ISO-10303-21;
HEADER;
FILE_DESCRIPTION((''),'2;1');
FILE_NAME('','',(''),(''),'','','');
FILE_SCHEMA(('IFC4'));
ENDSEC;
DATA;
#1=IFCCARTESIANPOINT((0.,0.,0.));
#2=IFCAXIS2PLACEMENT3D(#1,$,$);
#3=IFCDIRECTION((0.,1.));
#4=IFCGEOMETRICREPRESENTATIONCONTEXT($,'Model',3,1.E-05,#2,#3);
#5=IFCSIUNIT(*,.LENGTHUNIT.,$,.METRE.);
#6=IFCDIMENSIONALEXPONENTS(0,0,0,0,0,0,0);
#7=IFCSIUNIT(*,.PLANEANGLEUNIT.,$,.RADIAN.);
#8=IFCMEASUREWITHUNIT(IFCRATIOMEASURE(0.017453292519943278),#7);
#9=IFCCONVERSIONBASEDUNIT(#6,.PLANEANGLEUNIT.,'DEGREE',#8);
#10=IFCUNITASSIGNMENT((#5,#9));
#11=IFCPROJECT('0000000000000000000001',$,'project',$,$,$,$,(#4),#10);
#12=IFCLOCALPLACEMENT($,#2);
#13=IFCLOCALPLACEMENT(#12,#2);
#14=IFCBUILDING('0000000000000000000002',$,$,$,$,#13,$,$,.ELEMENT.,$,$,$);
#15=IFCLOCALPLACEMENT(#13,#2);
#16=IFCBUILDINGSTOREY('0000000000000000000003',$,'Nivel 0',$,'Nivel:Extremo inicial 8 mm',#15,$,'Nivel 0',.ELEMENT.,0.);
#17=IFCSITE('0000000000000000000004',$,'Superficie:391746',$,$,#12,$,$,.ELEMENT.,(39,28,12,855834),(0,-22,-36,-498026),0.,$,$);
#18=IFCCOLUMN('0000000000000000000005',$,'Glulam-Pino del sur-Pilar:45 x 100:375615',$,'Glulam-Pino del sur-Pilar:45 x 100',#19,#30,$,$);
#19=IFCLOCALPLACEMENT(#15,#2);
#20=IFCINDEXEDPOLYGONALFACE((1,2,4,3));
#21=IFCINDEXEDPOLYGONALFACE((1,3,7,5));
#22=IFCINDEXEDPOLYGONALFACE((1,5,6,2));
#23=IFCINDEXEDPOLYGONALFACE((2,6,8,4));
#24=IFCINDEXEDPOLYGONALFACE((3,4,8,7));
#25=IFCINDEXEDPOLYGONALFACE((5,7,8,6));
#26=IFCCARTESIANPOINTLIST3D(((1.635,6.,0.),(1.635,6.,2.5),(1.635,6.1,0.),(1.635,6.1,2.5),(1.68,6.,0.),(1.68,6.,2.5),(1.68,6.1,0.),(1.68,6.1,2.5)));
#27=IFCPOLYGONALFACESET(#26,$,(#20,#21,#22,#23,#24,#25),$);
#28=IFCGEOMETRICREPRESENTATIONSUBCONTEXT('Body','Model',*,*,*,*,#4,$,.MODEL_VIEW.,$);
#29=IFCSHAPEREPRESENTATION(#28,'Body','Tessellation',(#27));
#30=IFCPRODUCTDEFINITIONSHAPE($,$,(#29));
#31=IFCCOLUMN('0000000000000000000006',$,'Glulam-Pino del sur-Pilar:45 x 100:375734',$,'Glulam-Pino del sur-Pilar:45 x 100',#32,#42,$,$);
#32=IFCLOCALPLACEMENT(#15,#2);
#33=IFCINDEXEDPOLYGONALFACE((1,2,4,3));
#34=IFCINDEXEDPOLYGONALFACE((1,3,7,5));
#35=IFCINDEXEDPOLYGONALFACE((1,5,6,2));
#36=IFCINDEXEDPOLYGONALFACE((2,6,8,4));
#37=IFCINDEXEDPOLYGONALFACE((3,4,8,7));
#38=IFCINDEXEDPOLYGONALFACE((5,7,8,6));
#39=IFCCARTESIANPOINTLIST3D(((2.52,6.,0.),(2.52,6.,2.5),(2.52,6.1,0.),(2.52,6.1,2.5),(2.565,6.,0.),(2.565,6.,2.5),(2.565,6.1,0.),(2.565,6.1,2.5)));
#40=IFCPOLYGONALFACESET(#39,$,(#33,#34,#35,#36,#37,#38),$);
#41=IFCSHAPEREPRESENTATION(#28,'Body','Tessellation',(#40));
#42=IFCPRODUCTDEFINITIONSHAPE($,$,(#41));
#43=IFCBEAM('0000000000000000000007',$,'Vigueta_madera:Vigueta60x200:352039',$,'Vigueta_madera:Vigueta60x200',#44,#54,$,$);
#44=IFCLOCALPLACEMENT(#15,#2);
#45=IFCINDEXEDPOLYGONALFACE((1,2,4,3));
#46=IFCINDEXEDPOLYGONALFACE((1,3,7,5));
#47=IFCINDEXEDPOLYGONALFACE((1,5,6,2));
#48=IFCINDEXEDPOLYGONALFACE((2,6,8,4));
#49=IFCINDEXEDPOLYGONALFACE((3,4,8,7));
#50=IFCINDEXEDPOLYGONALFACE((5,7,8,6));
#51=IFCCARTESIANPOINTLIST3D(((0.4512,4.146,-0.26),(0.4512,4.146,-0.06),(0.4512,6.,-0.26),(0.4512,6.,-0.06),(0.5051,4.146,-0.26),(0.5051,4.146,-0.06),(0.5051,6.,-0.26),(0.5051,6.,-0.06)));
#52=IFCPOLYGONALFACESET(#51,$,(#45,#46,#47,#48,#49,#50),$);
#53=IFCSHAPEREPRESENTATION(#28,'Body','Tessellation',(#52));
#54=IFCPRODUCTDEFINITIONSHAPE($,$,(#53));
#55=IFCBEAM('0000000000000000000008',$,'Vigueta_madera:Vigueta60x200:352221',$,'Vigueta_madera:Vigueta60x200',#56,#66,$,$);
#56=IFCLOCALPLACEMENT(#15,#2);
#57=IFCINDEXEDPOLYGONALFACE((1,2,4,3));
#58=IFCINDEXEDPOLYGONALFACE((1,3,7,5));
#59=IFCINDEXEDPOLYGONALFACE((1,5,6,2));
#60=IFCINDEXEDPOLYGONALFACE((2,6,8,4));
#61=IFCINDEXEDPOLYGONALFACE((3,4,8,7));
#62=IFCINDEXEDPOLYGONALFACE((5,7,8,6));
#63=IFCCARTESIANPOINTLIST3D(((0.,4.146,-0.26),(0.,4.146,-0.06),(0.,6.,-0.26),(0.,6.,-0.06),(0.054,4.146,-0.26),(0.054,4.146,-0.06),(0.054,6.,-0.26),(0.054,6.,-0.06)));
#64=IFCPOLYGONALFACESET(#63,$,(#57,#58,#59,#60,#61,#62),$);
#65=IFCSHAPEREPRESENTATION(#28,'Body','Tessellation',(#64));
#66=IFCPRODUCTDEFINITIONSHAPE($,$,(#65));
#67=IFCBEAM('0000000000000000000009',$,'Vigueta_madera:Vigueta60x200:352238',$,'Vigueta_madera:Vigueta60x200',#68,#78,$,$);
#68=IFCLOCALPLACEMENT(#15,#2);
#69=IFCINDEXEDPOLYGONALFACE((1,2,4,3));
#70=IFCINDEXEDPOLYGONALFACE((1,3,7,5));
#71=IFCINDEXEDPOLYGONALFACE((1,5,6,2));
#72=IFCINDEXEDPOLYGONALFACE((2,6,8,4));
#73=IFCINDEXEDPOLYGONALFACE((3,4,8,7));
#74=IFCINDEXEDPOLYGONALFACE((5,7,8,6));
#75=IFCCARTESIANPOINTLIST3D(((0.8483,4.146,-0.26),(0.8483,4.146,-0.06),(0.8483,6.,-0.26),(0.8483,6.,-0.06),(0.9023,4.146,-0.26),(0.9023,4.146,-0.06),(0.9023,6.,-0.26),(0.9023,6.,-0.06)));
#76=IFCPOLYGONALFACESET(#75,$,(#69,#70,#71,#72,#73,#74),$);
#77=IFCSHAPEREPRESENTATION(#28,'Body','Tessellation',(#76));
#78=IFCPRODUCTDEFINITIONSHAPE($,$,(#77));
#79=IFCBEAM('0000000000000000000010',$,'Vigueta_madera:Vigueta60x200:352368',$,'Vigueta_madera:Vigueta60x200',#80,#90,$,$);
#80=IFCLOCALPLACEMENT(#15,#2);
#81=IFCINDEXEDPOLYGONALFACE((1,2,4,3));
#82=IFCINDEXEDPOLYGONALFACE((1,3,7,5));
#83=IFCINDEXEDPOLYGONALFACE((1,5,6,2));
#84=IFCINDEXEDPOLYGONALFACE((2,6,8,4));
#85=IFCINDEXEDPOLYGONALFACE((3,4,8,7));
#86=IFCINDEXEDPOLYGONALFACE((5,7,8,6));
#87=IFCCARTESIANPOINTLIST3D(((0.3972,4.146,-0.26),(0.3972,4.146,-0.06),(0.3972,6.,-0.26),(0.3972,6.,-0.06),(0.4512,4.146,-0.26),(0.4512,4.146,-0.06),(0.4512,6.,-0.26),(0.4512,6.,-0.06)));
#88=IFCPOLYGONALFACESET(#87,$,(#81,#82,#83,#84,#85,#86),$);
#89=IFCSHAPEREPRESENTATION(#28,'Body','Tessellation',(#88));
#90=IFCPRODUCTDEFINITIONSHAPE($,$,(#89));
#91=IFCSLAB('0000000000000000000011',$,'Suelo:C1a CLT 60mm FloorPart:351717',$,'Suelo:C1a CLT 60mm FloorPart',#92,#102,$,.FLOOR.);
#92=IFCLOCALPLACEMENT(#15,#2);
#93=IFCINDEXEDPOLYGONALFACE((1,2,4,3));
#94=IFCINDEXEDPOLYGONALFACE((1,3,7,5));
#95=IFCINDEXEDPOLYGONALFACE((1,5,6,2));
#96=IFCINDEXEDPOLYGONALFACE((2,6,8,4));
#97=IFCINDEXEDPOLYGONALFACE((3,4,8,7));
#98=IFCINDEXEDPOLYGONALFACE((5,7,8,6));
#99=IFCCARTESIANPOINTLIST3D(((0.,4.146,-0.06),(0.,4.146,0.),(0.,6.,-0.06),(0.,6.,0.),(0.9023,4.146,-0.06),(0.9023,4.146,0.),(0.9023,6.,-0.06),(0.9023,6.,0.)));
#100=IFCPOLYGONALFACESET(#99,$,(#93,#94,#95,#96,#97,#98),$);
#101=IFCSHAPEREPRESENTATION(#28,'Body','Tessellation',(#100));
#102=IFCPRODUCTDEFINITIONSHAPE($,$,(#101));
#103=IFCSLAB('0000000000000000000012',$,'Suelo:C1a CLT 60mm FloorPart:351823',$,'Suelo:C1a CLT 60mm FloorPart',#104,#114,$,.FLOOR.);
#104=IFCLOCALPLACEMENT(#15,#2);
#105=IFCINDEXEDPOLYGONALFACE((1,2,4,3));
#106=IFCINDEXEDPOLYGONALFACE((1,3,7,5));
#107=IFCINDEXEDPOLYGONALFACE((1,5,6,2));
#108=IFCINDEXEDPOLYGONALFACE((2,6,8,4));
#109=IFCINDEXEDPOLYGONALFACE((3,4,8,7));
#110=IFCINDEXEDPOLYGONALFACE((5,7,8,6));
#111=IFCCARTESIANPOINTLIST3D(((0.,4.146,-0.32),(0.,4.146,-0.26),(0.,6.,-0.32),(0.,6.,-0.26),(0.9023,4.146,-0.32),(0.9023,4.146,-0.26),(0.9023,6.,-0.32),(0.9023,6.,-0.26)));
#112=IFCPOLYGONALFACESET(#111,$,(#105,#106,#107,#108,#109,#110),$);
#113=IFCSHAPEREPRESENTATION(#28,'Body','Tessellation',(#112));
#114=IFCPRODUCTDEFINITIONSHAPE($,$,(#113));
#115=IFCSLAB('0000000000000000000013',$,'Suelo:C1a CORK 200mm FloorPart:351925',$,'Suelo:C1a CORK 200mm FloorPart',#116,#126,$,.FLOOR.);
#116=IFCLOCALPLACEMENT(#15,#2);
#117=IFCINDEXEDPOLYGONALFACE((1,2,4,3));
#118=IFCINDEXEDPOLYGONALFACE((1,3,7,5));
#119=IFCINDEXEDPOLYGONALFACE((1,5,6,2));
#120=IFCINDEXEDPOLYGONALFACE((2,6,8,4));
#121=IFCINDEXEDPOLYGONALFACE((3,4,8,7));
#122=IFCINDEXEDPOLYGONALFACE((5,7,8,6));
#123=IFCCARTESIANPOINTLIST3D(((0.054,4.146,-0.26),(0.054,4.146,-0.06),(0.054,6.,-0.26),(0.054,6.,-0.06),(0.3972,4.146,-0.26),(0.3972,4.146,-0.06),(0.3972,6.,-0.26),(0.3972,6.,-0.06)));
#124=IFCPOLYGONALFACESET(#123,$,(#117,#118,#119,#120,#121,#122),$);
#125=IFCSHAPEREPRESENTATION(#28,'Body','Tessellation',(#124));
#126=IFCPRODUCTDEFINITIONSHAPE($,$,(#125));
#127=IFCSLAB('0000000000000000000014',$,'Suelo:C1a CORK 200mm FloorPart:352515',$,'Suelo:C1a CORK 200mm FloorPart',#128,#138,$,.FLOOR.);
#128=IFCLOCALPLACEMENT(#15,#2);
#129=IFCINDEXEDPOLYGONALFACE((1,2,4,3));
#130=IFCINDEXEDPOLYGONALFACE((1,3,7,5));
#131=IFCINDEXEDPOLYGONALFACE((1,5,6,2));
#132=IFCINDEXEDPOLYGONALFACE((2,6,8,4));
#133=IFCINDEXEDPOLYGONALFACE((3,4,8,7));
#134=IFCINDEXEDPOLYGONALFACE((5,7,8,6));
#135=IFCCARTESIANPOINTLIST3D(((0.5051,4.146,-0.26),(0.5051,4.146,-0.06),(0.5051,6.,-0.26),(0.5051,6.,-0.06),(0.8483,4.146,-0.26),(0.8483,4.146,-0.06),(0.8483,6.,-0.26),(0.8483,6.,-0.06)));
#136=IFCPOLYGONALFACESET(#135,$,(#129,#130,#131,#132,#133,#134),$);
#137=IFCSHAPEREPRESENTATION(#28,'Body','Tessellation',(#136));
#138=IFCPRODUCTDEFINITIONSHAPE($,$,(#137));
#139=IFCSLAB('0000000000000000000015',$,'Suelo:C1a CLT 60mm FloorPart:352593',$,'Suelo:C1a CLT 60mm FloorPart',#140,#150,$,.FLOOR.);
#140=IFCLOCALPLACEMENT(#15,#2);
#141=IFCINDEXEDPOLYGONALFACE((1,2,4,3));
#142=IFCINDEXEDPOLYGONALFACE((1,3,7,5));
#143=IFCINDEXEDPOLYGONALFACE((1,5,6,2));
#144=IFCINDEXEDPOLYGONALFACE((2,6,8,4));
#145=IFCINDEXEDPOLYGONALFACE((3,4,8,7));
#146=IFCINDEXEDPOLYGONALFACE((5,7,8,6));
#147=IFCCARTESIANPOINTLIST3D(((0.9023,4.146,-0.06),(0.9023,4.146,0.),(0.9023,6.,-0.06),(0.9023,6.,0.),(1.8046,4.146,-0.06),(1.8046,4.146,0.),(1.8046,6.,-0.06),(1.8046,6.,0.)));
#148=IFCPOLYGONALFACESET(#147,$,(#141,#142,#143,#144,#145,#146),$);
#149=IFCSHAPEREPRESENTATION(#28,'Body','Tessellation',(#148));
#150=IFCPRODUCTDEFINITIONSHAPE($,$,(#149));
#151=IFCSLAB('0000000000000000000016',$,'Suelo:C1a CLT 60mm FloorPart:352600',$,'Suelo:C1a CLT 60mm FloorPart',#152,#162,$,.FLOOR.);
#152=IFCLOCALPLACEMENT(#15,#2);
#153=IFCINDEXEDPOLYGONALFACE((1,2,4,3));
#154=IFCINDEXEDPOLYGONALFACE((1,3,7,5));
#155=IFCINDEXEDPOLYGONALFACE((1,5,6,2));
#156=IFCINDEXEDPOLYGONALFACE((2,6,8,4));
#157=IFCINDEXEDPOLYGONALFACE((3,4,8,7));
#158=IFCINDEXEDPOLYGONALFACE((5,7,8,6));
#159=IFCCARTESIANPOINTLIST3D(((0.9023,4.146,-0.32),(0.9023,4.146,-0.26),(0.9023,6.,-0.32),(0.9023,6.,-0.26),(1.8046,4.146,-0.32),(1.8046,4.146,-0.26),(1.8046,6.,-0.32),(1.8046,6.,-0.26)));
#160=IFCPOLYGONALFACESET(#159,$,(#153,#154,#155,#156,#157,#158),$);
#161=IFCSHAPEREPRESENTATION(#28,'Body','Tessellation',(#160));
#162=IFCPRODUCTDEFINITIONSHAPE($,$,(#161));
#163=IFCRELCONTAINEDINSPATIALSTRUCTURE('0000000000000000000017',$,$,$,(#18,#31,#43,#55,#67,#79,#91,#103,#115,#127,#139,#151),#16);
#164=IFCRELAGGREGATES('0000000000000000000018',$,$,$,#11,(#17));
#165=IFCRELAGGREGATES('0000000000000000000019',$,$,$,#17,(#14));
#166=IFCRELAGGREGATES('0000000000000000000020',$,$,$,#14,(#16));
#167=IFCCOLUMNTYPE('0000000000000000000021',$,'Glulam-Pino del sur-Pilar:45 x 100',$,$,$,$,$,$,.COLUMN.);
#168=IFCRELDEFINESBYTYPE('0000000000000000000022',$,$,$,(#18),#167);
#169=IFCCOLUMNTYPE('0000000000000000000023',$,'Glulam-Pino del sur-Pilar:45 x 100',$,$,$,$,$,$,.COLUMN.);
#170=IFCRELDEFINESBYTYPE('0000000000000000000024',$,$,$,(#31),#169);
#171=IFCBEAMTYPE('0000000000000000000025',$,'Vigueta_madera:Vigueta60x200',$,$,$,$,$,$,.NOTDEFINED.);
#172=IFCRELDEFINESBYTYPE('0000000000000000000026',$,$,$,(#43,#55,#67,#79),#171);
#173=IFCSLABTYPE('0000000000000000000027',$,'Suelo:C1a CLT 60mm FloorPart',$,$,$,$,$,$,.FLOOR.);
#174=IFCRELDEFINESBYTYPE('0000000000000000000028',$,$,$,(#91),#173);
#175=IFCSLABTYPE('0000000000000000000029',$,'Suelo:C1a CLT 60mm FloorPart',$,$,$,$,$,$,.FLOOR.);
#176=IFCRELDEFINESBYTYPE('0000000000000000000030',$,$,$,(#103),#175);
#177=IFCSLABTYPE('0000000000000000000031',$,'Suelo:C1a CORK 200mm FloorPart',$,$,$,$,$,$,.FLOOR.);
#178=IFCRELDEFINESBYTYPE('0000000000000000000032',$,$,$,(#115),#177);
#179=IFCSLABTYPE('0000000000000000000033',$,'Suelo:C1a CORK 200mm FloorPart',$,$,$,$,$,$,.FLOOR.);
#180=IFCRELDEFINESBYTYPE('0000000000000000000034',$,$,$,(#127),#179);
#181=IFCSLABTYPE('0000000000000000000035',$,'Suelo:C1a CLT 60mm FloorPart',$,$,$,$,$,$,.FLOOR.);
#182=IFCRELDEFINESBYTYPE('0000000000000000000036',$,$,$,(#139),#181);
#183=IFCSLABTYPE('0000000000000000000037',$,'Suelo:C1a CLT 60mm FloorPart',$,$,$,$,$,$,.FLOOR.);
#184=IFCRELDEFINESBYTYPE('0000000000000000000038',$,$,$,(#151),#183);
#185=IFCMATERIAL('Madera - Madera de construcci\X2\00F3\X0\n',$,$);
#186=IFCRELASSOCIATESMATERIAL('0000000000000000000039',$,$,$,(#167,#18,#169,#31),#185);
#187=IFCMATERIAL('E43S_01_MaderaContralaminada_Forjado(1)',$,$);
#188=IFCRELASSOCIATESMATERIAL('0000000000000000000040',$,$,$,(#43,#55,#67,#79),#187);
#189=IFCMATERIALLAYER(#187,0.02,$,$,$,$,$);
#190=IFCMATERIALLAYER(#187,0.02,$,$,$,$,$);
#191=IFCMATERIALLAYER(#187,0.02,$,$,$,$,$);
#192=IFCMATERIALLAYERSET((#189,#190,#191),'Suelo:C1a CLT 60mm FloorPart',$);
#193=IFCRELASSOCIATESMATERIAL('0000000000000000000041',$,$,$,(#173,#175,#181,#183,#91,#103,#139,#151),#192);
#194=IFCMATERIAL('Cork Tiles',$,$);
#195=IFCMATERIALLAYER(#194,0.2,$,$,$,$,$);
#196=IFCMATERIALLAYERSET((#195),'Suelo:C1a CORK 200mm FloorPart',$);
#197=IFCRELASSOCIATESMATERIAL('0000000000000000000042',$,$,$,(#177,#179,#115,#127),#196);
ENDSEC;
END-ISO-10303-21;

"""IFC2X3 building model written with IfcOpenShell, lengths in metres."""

from ifc_helpers import new_model, entity, si_unit, converted_unit, direction, frame, frame_2d, origin, origin_2d_with_axis, place, context, subcontext, project, spatial, rectangle, extrude, source, transform, mapped, material, layer, layer_set, layer_usage, type_object, type_shapes, element, save


model = new_model("IFC2X3")

# Units and contexts
model_context = context("Model", 3, precision=1e-05, world=origin(), true_north=direction((0.0, 1.0)))
body_context = subcontext(model_context, "Body", "Model", "MODEL_VIEW")
ifc_project = project(units=[si_unit("LENGTHUNIT", "METRE"), converted_unit("PLANEANGLEUNIT", "DEGREE", entity("IfcRatioMeasure", 0.017453292519943278), si_unit("PLANEANGLEUNIT", "RADIAN"), dimensions=[0, 0, 0, 0, 0, 0, 0])], contexts=[model_context])

# Site, building, storey
site_placement = place(None, origin())
site = spatial("IfcSite", under=ifc_project, at=site_placement, Name="Superficie:391746", CompositionType="ELEMENT", RefLatitude=(39, 28, 12, 855834), RefLongitude=(0, -22, -36, -498026), RefElevation=0.0)
building_placement = place(site_placement, origin())
building = spatial("IfcBuilding", under=site, at=building_placement, CompositionType="ELEMENT")
storey_placement = place(building_placement, origin())
storey = spatial("IfcBuildingStorey", under=building, at=storey_placement, Name="Nivel 0", ObjectType="Nivel:Extremo inicial 8 mm", LongName="Nivel 0", CompositionType="ELEMENT", Elevation=0.0)

# Columns
ifc_material_1 = material(Name="Madera - Madera de construcción")
column_type_1 = type_object("IfcColumnType", Name="Glulam-Pino del sur-Pilar:45 x 100", PredefinedType="COLUMN", material=ifc_material_1)
shared_shape_1 = source(origin(), body_context, "Body", "SweptSolid", [
    extrude(rectangle(XDim=0.1, YDim=0.045, at=origin_2d_with_axis()), frame((0.0, 0.0, 0.0), z_axis=(0.0, 0.0, 1.0), x_axis=(0.0, -1.0, 0.0)), (0.0, 0.0, 1.0), 2.5),
])
type_shapes(column_type_1, [shared_shape_1])
column_1_placement = place(storey_placement, frame((1.6575, 6.05, 0.0)))
element("IfcColumn", 1, at=column_1_placement, inside=storey, type_object=column_type_1, material=ifc_material_1, Name="Glulam-Pino del sur-Pilar:45 x 100:375615", ObjectType="Glulam-Pino del sur-Pilar:45 x 100", context=body_context, shape_type="MappedRepresentation", body=[
    mapped(shared_shape_1, transform((0.0, 0.0, 0.0), scale=1.0)),
])
column_type_2 = type_object("IfcColumnType", Name="Glulam-Pino del sur-Pilar:45 x 100", PredefinedType="COLUMN", material=ifc_material_1)
shared_shape_2 = source(origin(), body_context, "Body", "SweptSolid", [
    extrude(rectangle(XDim=0.1, YDim=0.045, at=origin_2d_with_axis()), frame((0.0, 0.0, 0.0), z_axis=(0.0, 0.0, 1.0), x_axis=(0.0, -1.0, 0.0)), (0.0, 0.0, 1.0), 2.5),
])
type_shapes(column_type_2, [shared_shape_2])
column_2_placement = place(storey_placement, frame((2.5425, 6.05, 0.0), z_axis=(0.0, 0.0, 1.0), x_axis=(-1.0, 0.0, 0.0)))
element("IfcColumn", 2, at=column_2_placement, inside=storey, type_object=column_type_2, material=ifc_material_1, Name="Glulam-Pino del sur-Pilar:45 x 100:375734", ObjectType="Glulam-Pino del sur-Pilar:45 x 100", context=body_context, shape_type="MappedRepresentation", body=[
    mapped(shared_shape_2, transform((0.0, 0.0, 0.0), scale=1.0)),
])

# Beams
ifc_material_2 = material(Name="E43S_01_MaderaContralaminada_Forjado(1)")
beam_type = type_object("IfcBeamType", Name="Vigueta_madera:Vigueta60x200", PredefinedType="NOTDEFINED")
beam_1_placement = place(storey_placement, frame((0.4781, 4.146, -0.06), z_axis=(0.0, 0.0, 1.0), x_axis=(0.0, 1.0, 0.0)))
element("IfcBeam", 3, at=beam_1_placement, inside=storey, type_object=beam_type, material=ifc_material_2, Name="Vigueta_madera:Vigueta60x200:352039", ObjectType="Vigueta_madera:Vigueta60x200", context=body_context, shape_type="SweptSolid", body=[
    extrude(rectangle(XDim=0.2, YDim=0.054, at=frame_2d((0.0, 0.0), x_axis=(1.0, 0.0))), frame((0.0, 0.0, -0.1), z_axis=(1.0, 0.0, 0.0), x_axis=(0.0, 0.0, -1.0)), (0.0, 0.0, 1.0), 1.854),
])
beam_2_placement = place(storey_placement, frame((0.027, 4.146, -0.06), z_axis=(0.0, 0.0, 1.0), x_axis=(0.0, 1.0, 0.0)))
element("IfcBeam", 4, at=beam_2_placement, inside=storey, type_object=beam_type, material=ifc_material_2, Name="Vigueta_madera:Vigueta60x200:352221", ObjectType="Vigueta_madera:Vigueta60x200", context=body_context, shape_type="SweptSolid", body=[
    extrude(rectangle(XDim=0.2, YDim=0.054, at=frame_2d((0.0, 0.0), x_axis=(1.0, 0.0))), frame((0.0, 0.0, -0.1), z_axis=(1.0, 0.0, 0.0), x_axis=(0.0, 0.0, -1.0)), (0.0, 0.0, 1.0), 1.854),
])
beam_3_placement = place(storey_placement, frame((0.8753, 4.146, -0.06), z_axis=(0.0, 0.0, 1.0), x_axis=(0.0, 1.0, 0.0)))
element("IfcBeam", 5, at=beam_3_placement, inside=storey, type_object=beam_type, material=ifc_material_2, Name="Vigueta_madera:Vigueta60x200:352238", ObjectType="Vigueta_madera:Vigueta60x200", context=body_context, shape_type="SweptSolid", body=[
    extrude(rectangle(XDim=0.2, YDim=0.054, at=frame_2d((0.0, 0.0), x_axis=(1.0, 0.0))), frame((0.0, 0.0, -0.1), z_axis=(1.0, 0.0, 0.0), x_axis=(0.0, 0.0, -1.0)), (0.0, 0.0, 1.0), 1.854),
])
beam_4_placement = place(storey_placement, frame((0.4242, 4.146, -0.06), z_axis=(0.0, 0.0, 1.0), x_axis=(0.0, 1.0, 0.0)))
element("IfcBeam", 6, at=beam_4_placement, inside=storey, type_object=beam_type, material=ifc_material_2, Name="Vigueta_madera:Vigueta60x200:352368", ObjectType="Vigueta_madera:Vigueta60x200", context=body_context, shape_type="SweptSolid", body=[
    extrude(rectangle(XDim=0.2, YDim=0.054, at=frame_2d((0.0, 0.0), x_axis=(1.0, 0.0))), frame((0.0, 0.0, -0.1), z_axis=(1.0, 0.0, 0.0), x_axis=(0.0, 0.0, -1.0)), (0.0, 0.0, 1.0), 1.854),
])

# Slabs
ifc_layer_1 = layer(ifc_material_2, 0.02)
ifc_layer_2 = layer(ifc_material_2, 0.02)
ifc_layer_3 = layer(ifc_material_2, 0.02)
ifc_layer_set_1 = layer_set([ifc_layer_1, ifc_layer_2, ifc_layer_3], Name="Suelo:C1a CLT 60mm FloorPart")
ifc_layer_usage_1 = layer_usage(ifc_layer_set_1, "AXIS3", "POSITIVE", 0.0)
slab_type_1 = type_object("IfcSlabType", Name="Suelo:C1a CLT 60mm FloorPart", PredefinedType="FLOOR", material=ifc_layer_set_1)
slab_1_placement = place(storey_placement, origin())
element("IfcSlab", 7, at=slab_1_placement, inside=storey, type_object=slab_type_1, material=ifc_layer_usage_1, Name="Suelo:C1a CLT 60mm FloorPart:351717", ObjectType="Suelo:C1a CLT 60mm FloorPart", PredefinedType="FLOOR", context=body_context, shape_type="SweptSolid", body=[
    extrude(rectangle(XDim=1.854, YDim=0.9023, at=frame_2d((0.0, 0.0), x_axis=(1.0, 0.0))), frame((0.4512, 5.073, 0.0), z_axis=(0.0, 0.0, -1.0), x_axis=(0.0, 1.0, 0.0)), (0.0, 0.0, 1.0), 0.06),
])
ifc_layer_usage_2 = layer_usage(ifc_layer_set_1, "AXIS3", "POSITIVE", 0.0)
slab_type_2 = type_object("IfcSlabType", Name="Suelo:C1a CLT 60mm FloorPart", PredefinedType="FLOOR", material=ifc_layer_set_1)
slab_2_placement = place(storey_placement, origin())
element("IfcSlab", 8, at=slab_2_placement, inside=storey, type_object=slab_type_2, material=ifc_layer_usage_2, Name="Suelo:C1a CLT 60mm FloorPart:351823", ObjectType="Suelo:C1a CLT 60mm FloorPart", PredefinedType="FLOOR", context=body_context, shape_type="SweptSolid", body=[
    extrude(rectangle(XDim=1.854, YDim=0.9023, at=frame_2d((0.0, 0.0), x_axis=(1.0, 0.0))), frame((0.4512, 5.073, -0.26), z_axis=(0.0, 0.0, -1.0), x_axis=(0.0, 1.0, 0.0)), (0.0, 0.0, 1.0), 0.06),
])
ifc_material_3 = material(Name="Cork Tiles")
ifc_layer_4 = layer(ifc_material_3, 0.2)
ifc_layer_set_2 = layer_set([ifc_layer_4], Name="Suelo:C1a CORK 200mm FloorPart")
ifc_layer_usage_3 = layer_usage(ifc_layer_set_2, "AXIS3", "POSITIVE", 0.0)
slab_type_3 = type_object("IfcSlabType", Name="Suelo:C1a CORK 200mm FloorPart", PredefinedType="FLOOR", material=ifc_layer_set_2)
slab_3_placement = place(storey_placement, origin())
element("IfcSlab", 9, at=slab_3_placement, inside=storey, type_object=slab_type_3, material=ifc_layer_usage_3, Name="Suelo:C1a CORK 200mm FloorPart:351925", ObjectType="Suelo:C1a CORK 200mm FloorPart", PredefinedType="FLOOR", context=body_context, shape_type="SweptSolid", body=[
    extrude(rectangle(XDim=1.854, YDim=0.3432, at=frame_2d((0.0, 0.0), x_axis=(1.0, 0.0))), frame((0.2256, 5.073, -0.06), z_axis=(0.0, 0.0, -1.0), x_axis=(0.0, 1.0, 0.0)), (0.0, 0.0, 1.0), 0.2),
])
ifc_layer_usage_4 = layer_usage(ifc_layer_set_2, "AXIS3", "POSITIVE", 0.0)
slab_type_4 = type_object("IfcSlabType", Name="Suelo:C1a CORK 200mm FloorPart", PredefinedType="FLOOR", material=ifc_layer_set_2)
slab_4_placement = place(storey_placement, origin())
element("IfcSlab", 10, at=slab_4_placement, inside=storey, type_object=slab_type_4, material=ifc_layer_usage_4, Name="Suelo:C1a CORK 200mm FloorPart:352515", ObjectType="Suelo:C1a CORK 200mm FloorPart", PredefinedType="FLOOR", context=body_context, shape_type="SweptSolid", body=[
    extrude(rectangle(XDim=1.854, YDim=0.3432, at=frame_2d((0.0, 0.0), x_axis=(1.0, 0.0))), frame((0.6767, 5.073, -0.06), z_axis=(0.0, 0.0, -1.0), x_axis=(0.0, 1.0, 0.0)), (0.0, 0.0, 1.0), 0.2),
])
ifc_layer_usage_5 = layer_usage(ifc_layer_set_1, "AXIS3", "POSITIVE", 0.0)
slab_type_5 = type_object("IfcSlabType", Name="Suelo:C1a CLT 60mm FloorPart", PredefinedType="FLOOR", material=ifc_layer_set_1)
slab_5_placement = place(storey_placement, origin())
element("IfcSlab", 11, at=slab_5_placement, inside=storey, type_object=slab_type_5, material=ifc_layer_usage_5, Name="Suelo:C1a CLT 60mm FloorPart:352593", ObjectType="Suelo:C1a CLT 60mm FloorPart", PredefinedType="FLOOR", context=body_context, shape_type="SweptSolid", body=[
    extrude(rectangle(XDim=1.854, YDim=0.9023, at=frame_2d((0.0, 0.0), x_axis=(1.0, 0.0))), frame((1.3535, 5.073, 0.0), z_axis=(0.0, 0.0, -1.0), x_axis=(0.0, 1.0, 0.0)), (0.0, 0.0, 1.0), 0.06),
])
ifc_layer_usage_6 = layer_usage(ifc_layer_set_1, "AXIS3", "POSITIVE", 0.0)
slab_type_6 = type_object("IfcSlabType", Name="Suelo:C1a CLT 60mm FloorPart", PredefinedType="FLOOR", material=ifc_layer_set_1)
slab_6_placement = place(storey_placement, origin())
element("IfcSlab", 12, at=slab_6_placement, inside=storey, type_object=slab_type_6, material=ifc_layer_usage_6, Name="Suelo:C1a CLT 60mm FloorPart:352600", ObjectType="Suelo:C1a CLT 60mm FloorPart", PredefinedType="FLOOR", context=body_context, shape_type="SweptSolid", body=[
    extrude(rectangle(XDim=1.854, YDim=0.9023, at=frame_2d((0.0, 0.0), x_axis=(1.0, 0.0))), frame((1.3535, 5.073, -0.26), z_axis=(0.0, 0.0, -1.0), x_axis=(0.0, 1.0, 0.0)), (0.0, 0.0, 1.0), 0.06),
])

save(model, "model.ifc")
